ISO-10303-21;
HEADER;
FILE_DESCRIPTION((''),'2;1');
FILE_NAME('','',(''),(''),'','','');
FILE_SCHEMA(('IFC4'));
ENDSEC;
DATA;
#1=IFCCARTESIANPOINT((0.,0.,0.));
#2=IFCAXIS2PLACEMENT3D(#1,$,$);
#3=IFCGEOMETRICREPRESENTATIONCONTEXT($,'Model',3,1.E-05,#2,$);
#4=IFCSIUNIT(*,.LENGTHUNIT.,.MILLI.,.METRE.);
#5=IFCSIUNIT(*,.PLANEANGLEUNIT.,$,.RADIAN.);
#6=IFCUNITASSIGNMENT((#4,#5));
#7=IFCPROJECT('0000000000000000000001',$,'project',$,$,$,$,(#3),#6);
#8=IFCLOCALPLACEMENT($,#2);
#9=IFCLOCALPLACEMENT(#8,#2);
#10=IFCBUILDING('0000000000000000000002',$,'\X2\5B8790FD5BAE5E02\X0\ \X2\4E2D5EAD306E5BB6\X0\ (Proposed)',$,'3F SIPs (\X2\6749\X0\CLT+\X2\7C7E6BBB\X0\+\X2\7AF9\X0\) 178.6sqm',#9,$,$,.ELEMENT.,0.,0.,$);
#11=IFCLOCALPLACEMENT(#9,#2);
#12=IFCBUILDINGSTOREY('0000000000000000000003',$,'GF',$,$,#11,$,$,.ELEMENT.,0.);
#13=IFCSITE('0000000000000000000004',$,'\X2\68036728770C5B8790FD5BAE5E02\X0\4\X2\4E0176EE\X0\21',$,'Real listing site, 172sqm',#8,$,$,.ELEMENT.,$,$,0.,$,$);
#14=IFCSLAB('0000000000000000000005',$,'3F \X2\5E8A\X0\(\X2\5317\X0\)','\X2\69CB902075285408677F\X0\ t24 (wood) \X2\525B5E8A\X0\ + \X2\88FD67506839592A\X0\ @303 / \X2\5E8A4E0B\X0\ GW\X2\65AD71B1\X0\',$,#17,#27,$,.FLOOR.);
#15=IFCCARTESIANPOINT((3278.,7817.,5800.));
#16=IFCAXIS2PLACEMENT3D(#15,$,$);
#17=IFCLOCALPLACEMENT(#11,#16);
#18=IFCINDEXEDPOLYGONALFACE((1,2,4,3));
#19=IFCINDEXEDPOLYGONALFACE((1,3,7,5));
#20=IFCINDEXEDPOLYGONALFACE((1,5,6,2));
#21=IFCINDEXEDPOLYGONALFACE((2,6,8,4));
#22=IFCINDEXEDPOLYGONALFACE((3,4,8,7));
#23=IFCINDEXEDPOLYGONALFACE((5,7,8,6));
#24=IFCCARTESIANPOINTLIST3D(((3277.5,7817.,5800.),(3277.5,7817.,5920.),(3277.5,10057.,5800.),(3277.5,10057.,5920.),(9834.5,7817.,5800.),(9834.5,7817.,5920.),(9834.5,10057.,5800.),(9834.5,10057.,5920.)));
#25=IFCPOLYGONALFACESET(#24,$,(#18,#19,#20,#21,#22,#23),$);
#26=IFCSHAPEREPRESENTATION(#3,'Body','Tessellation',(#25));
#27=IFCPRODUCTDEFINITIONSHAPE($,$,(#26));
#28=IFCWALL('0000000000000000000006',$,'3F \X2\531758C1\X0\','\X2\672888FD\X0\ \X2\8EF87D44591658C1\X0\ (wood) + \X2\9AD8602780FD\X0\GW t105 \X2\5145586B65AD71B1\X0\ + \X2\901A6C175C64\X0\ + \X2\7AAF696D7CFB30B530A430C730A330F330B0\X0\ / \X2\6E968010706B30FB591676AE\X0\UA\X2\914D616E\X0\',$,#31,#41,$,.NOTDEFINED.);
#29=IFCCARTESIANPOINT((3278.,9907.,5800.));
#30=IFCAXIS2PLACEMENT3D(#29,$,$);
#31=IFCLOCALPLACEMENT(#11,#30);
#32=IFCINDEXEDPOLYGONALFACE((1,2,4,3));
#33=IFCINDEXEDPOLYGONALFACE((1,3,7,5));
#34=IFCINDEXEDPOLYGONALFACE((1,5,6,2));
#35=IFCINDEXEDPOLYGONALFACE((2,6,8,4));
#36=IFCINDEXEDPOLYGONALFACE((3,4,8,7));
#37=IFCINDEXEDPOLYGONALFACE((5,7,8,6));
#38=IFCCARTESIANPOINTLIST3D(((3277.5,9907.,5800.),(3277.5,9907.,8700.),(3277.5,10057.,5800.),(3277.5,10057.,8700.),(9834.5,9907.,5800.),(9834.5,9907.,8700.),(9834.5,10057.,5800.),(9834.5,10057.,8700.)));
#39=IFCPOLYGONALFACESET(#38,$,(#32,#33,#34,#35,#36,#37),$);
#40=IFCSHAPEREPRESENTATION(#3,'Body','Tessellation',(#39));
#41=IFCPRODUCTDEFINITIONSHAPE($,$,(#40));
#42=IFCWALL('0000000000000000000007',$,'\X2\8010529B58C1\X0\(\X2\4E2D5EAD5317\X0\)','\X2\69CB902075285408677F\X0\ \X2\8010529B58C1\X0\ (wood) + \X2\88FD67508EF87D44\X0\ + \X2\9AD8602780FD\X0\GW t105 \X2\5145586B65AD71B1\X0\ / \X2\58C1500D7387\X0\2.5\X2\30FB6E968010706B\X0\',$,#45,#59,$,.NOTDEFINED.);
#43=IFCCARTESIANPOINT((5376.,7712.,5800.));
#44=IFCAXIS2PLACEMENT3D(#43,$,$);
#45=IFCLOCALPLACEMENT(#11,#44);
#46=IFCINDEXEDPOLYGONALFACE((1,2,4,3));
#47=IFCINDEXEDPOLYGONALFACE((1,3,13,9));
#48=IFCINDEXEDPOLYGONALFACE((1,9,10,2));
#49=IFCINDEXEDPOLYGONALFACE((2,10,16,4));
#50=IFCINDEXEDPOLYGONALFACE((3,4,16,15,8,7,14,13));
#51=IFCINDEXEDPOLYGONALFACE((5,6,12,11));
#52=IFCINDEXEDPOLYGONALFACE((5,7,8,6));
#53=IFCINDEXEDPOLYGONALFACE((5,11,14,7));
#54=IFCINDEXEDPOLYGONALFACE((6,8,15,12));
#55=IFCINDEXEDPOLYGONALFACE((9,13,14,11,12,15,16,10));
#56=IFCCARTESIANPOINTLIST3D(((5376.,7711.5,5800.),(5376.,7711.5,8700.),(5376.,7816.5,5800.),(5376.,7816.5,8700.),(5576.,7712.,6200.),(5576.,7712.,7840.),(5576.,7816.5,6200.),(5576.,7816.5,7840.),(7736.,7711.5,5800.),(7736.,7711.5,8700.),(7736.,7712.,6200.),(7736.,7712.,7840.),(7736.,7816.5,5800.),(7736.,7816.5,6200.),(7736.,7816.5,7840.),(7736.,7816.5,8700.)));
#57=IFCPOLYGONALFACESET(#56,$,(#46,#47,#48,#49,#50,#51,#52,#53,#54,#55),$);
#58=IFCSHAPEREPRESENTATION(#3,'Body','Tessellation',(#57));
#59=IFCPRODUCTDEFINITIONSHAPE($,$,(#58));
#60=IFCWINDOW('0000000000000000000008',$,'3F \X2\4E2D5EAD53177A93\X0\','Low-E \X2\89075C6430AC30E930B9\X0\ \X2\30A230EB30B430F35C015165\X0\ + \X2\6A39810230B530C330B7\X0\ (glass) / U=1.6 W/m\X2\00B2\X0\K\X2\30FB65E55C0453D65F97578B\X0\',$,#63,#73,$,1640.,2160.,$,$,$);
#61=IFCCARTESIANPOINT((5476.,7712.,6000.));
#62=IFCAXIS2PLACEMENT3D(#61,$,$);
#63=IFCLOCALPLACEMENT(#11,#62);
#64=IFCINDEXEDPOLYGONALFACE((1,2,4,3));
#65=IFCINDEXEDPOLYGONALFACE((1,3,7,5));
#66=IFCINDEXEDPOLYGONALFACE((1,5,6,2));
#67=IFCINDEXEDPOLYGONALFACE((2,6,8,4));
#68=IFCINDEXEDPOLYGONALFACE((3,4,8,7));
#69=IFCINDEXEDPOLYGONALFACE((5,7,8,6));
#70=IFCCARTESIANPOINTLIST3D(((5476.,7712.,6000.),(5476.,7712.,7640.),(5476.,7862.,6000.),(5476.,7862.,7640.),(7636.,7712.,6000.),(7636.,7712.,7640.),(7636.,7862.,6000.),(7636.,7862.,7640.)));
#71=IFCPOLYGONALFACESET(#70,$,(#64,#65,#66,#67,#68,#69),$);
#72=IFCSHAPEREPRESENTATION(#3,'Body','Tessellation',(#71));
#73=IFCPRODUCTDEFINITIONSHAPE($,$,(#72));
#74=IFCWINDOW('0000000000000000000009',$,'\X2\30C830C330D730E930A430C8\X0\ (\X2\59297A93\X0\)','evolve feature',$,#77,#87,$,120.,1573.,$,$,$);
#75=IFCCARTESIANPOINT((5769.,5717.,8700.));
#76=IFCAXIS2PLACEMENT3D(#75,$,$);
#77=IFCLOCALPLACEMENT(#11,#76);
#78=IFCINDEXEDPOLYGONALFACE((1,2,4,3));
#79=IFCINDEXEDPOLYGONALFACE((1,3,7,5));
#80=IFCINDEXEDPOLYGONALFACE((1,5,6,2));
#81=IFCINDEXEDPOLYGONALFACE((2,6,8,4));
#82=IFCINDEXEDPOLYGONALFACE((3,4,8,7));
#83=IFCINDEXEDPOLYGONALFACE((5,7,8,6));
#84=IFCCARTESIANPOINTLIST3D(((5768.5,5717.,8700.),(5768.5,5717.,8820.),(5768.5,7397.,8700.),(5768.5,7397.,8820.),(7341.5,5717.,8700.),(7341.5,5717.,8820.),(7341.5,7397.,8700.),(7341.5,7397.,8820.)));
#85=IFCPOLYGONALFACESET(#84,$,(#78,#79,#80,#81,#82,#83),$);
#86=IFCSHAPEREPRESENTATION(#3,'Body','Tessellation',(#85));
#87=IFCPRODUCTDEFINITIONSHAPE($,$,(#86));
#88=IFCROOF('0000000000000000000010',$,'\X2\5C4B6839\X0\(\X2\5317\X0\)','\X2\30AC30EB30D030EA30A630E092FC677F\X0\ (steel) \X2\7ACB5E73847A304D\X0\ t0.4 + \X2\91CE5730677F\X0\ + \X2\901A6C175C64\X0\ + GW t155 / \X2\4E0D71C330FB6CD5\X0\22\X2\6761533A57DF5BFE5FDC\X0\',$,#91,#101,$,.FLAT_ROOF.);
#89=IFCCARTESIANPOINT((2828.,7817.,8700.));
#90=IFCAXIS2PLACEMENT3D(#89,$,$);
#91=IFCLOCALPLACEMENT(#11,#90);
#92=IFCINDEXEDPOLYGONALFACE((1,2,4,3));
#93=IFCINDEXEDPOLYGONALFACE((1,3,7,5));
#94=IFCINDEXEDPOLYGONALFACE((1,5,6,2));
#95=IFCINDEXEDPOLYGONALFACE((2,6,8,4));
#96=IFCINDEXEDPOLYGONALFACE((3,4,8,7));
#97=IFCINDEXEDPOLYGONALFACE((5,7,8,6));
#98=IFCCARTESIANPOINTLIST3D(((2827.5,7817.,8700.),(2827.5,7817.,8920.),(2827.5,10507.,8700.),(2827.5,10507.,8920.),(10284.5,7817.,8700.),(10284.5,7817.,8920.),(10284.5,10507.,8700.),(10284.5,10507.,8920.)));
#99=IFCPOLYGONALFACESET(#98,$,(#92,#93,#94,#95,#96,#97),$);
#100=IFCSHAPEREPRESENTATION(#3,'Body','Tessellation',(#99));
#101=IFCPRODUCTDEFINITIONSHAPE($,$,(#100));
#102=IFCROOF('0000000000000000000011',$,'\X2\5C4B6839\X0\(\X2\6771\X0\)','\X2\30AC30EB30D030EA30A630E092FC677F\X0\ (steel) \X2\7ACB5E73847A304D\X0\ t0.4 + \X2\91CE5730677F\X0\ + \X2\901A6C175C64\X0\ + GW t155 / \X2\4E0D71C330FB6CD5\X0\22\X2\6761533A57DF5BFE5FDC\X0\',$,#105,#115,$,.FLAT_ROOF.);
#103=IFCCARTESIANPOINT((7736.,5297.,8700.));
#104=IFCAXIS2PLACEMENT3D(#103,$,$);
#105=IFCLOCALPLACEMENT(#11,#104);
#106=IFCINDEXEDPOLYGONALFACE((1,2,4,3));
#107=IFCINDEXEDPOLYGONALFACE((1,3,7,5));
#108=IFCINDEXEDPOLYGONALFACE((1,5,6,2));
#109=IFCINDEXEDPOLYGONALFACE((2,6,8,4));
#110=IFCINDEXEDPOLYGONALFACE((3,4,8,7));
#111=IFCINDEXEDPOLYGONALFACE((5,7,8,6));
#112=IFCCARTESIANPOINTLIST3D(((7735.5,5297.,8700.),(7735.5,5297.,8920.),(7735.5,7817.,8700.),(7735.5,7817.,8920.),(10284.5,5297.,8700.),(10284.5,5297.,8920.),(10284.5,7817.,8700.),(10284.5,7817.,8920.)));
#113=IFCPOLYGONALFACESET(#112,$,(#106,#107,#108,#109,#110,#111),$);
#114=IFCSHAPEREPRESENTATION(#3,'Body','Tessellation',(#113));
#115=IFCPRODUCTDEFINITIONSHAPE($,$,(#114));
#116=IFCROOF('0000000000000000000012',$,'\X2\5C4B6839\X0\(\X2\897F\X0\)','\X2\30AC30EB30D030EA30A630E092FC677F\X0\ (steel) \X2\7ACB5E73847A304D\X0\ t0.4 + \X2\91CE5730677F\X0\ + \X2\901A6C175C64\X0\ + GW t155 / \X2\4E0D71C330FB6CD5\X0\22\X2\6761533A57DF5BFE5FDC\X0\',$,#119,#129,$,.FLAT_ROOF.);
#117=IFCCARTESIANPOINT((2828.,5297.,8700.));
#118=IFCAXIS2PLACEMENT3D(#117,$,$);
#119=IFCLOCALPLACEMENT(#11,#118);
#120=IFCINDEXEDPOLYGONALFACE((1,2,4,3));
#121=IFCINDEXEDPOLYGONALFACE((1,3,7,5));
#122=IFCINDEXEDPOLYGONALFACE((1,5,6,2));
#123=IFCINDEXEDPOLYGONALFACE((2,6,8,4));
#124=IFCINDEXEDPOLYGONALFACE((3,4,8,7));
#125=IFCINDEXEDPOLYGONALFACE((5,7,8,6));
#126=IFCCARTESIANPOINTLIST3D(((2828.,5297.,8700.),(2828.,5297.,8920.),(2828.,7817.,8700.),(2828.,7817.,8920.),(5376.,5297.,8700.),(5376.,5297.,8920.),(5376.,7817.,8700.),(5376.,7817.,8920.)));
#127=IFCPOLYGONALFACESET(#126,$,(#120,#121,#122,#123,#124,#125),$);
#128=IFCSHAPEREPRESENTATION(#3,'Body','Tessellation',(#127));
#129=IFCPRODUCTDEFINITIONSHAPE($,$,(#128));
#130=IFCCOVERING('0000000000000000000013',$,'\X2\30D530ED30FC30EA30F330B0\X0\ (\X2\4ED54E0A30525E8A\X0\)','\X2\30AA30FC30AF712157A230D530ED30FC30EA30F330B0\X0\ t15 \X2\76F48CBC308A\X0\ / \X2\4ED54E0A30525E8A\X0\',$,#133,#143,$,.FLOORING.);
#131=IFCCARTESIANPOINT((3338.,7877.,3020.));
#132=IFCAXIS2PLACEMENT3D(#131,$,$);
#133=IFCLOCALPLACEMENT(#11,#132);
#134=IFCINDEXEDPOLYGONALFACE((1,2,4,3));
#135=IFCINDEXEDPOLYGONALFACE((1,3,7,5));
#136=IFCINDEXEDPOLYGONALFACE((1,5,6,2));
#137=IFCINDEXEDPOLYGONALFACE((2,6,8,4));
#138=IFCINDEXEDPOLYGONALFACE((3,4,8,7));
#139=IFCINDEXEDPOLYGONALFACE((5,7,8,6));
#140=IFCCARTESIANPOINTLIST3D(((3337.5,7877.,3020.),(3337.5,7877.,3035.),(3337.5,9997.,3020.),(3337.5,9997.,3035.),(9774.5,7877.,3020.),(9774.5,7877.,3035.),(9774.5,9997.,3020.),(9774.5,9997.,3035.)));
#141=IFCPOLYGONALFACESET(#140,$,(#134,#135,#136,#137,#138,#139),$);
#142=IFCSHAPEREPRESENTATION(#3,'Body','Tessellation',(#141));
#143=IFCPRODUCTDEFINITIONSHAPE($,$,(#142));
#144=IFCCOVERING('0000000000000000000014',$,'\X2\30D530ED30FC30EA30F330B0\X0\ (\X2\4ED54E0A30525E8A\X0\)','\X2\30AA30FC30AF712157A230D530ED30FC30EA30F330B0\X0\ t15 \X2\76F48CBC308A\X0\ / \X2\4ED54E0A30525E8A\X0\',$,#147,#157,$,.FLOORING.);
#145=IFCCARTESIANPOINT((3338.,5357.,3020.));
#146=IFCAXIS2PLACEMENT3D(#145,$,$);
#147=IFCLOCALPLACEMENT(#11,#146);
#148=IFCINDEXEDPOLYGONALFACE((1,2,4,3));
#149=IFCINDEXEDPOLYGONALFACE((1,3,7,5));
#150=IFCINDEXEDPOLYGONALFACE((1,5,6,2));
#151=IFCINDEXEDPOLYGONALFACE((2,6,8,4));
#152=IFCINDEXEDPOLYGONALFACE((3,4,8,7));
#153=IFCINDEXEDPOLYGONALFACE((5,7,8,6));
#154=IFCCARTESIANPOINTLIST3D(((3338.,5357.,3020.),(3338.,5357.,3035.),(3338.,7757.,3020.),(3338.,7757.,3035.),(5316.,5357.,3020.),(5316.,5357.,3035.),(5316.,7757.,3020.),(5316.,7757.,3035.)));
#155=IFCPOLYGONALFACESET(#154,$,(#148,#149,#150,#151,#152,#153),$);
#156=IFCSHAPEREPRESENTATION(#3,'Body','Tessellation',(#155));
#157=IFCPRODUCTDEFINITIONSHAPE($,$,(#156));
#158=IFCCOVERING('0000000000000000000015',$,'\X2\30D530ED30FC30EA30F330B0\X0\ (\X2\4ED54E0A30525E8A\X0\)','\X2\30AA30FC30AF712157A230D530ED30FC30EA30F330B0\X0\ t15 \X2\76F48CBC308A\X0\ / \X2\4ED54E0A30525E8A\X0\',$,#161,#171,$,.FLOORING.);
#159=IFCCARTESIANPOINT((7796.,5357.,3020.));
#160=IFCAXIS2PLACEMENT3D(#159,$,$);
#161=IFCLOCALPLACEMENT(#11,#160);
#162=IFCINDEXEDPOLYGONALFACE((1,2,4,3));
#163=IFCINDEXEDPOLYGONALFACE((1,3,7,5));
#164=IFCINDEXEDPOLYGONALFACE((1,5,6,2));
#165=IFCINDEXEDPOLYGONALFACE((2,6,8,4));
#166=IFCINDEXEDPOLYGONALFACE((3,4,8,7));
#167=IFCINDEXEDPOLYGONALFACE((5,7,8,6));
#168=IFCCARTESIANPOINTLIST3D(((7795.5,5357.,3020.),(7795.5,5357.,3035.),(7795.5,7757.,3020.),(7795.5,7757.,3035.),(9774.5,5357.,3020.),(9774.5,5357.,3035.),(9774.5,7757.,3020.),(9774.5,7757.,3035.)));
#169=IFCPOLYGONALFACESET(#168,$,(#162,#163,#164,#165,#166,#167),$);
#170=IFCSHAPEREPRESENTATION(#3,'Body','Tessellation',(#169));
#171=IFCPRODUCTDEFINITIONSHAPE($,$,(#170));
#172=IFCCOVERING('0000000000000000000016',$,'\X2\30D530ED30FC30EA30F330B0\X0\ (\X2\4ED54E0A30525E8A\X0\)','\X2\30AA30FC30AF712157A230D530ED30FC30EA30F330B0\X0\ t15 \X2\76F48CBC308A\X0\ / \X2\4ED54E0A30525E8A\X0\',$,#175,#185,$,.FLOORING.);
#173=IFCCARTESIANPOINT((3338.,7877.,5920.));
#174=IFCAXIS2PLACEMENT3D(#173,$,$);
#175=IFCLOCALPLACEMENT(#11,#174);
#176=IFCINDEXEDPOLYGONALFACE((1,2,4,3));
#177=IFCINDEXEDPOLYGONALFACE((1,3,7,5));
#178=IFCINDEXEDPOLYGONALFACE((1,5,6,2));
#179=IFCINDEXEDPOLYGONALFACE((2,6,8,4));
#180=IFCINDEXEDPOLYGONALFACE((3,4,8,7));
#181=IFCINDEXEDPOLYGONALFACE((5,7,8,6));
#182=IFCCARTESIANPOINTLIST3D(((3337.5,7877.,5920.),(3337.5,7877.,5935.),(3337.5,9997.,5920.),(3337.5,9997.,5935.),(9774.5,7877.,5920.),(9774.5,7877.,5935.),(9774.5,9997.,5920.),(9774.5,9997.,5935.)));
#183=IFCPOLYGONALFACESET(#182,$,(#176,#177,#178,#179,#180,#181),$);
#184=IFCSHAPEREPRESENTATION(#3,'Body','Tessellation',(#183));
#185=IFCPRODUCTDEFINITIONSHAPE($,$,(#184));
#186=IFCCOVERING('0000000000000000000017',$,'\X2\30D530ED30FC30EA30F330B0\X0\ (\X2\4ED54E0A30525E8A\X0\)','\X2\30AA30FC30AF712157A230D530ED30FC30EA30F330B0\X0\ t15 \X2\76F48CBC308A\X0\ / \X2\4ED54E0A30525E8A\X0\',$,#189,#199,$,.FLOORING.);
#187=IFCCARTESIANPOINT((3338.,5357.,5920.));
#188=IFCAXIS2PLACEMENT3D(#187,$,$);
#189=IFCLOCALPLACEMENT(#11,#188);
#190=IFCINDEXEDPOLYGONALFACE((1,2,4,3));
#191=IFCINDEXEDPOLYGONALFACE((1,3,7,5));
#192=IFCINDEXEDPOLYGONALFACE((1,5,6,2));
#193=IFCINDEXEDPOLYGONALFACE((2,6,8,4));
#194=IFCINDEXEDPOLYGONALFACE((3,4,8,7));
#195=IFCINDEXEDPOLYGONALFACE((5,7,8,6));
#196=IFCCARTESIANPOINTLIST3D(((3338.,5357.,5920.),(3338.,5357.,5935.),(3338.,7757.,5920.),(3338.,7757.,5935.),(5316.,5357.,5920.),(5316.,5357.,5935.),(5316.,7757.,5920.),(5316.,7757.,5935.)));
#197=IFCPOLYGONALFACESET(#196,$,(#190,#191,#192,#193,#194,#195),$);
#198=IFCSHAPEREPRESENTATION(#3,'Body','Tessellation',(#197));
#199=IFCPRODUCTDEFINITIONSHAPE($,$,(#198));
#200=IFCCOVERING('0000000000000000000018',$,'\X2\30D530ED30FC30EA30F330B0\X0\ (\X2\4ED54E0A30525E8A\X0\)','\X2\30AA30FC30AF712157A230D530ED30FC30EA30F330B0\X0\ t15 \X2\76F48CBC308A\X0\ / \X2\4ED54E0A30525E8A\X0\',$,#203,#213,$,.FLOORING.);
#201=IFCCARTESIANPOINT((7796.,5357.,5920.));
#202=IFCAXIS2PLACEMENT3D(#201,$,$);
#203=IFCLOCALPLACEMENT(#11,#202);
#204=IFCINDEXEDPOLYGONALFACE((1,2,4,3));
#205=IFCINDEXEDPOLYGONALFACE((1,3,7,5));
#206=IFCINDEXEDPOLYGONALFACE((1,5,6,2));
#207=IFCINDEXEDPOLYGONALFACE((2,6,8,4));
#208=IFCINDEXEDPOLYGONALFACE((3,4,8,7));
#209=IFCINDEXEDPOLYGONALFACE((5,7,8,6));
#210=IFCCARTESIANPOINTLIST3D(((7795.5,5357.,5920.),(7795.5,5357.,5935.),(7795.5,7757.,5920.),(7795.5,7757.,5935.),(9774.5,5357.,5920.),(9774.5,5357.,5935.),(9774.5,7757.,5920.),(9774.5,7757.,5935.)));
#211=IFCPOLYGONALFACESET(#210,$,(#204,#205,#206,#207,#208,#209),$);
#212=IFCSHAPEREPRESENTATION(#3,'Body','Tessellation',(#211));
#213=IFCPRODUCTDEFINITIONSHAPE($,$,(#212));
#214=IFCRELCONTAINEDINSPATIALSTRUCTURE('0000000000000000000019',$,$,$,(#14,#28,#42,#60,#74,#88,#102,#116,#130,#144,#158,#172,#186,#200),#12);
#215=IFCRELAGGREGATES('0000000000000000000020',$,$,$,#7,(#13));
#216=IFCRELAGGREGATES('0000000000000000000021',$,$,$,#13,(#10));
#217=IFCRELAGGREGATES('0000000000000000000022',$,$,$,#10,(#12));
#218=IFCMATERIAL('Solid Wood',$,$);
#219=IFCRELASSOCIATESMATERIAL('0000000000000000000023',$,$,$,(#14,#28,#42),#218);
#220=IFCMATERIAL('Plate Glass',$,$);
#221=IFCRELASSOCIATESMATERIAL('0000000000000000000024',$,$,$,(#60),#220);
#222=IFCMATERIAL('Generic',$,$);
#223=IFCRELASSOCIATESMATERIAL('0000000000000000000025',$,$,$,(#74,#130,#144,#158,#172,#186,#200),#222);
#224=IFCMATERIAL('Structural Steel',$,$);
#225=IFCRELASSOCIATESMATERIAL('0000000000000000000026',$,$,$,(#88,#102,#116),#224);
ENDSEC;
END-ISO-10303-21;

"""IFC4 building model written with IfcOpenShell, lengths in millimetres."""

from ifc_helpers import new_model, si_unit, frame, frame_2d, origin, place, context, project, spatial, rectangle, extrude, material, element, fill, save


model = new_model("IFC4")

# Units and contexts
model_context = context("Model", 3, precision=1e-05, world=origin())
ifc_project = project(units=[si_unit("LENGTHUNIT", "METRE", prefix="MILLI"), si_unit("PLANEANGLEUNIT", "RADIAN")], contexts=[model_context])

# Site, building, storey
site_placement = place(None, origin())
site = spatial("IfcSite", under=ifc_project, at=site_placement, Name="栃木県宇都宮市4丁目21", ObjectType="Real listing site, 172sqm", CompositionType="ELEMENT", RefElevation=0.0)
building_placement = place(site_placement, origin())
building = spatial("IfcBuilding", under=site, at=building_placement, Name="宇都宮市 中庭の家 (Proposed)", ObjectType="3F SIPs (杉CLT+籾殻+竹) 178.6sqm", CompositionType="ELEMENT", ElevationOfRefHeight=0.0, ElevationOfTerrain=0.0)
storey_placement = place(building_placement, origin())
storey = spatial("IfcBuildingStorey", under=building, at=storey_placement, Name="GF", CompositionType="ELEMENT", Elevation=0.0)

# Slab
ifc_material_1 = material(Name="Solid Wood")
slab_placement = place(storey_placement, frame((3278.0, 7817.0, 5800.0)))
element("IfcSlab", 1, at=slab_placement, inside=storey, material=ifc_material_1, Name="3F 床(北)", Description="構造用合板 t24 (wood) 剛床 + 製材根太 @303 / 床下 GW断熱", PredefinedType="FLOOR", context=model_context, shape_type="SweptSolid", body=[
    extrude(rectangle(XDim=6557.0, YDim=2240.0, at=frame_2d((3278.0, 1120.0))), frame((3278.0, 7817.0, 5800.0)), (0.0, 0.0, 1.0), 120.0),
])

# Wall
wall_1_placement = place(storey_placement, frame((3278.0, 9907.0, 5800.0)))
element("IfcWall", 2, at=wall_1_placement, inside=storey, material=ifc_material_1, Name="3F 北壁", Description="木製 軸組外壁 (wood) + 高性能GW t105 充填断熱 + 通気層 + 窯業系サイディング / 準耐火・外皮UA配慮", PredefinedType="NOTDEFINED", context=model_context, shape_type="SweptSolid", body=[
    extrude(rectangle(XDim=6557.0, YDim=150.0, at=frame_2d((3278.0, 75.0))), frame((3278.0, 9907.0, 5800.0)), (0.0, 0.0, 1.0), 2900.0),
])

# Wall, opening, window
wall_2_placement = place(storey_placement, frame((5376.0, 7712.0, 5800.0)))
wall_2 = element("IfcWall", 3, at=wall_2_placement, inside=storey, material=ifc_material_1, Name="耐力壁(中庭北)", Description="構造用合板 耐力壁 (wood) + 製材軸組 + 高性能GW t105 充填断熱 / 壁倍率2.5・準耐火", PredefinedType="NOTDEFINED", context=model_context, shape_type="SweptSolid", body=[
    extrude(rectangle(XDim=2360.0, YDim=105.0, at=frame_2d((1180.0, 52.0))), frame((5376.0, 7712.0, 5800.0)), (0.0, 0.0, 1.0), 2900.0),
])
opening_placement = place(storey_placement, frame((5476.0, 7712.0, 6000.0)))
opening = element("IfcOpeningElement", 4, at=opening_placement, cuts=wall_2, PredefinedType="NOTDEFINED", context=model_context, shape_type="SweptSolid", body=[
    extrude(rectangle(XDim=2160.0, YDim=150.0, at=frame_2d((1080.0, 75.0))), frame((5476.0, 7712.0, 6000.0)), (0.0, 0.0, 1.0), 1640.0),
])
ifc_material_2 = material(Name="Plate Glass")
window_1_placement = place(storey_placement, frame((5476.0, 7712.0, 6000.0)))
window_1 = element("IfcWindow", 5, at=window_1_placement, inside=storey, material=ifc_material_2, Name="3F 中庭北窓", Description="Low-E 複層ガラス アルゴン封入 + 樹脂サッシ (glass) / U=1.6 W/m²K・日射取得型", OverallHeight=1640.0, OverallWidth=2160.0, context=model_context, shape_type="SweptSolid", body=[
    extrude(rectangle(XDim=2160.0, YDim=150.0, at=frame_2d((1080.0, 75.0))), frame((5476.0, 7712.0, 6000.0)), (0.0, 0.0, 1.0), 1640.0),
])
fill(opening, window_1)

# Window
ifc_material_3 = material(Name="Generic")
window_2_placement = place(storey_placement, frame((5769.0, 5717.0, 8700.0)))
element("IfcWindow", 6, at=window_2_placement, inside=storey, material=ifc_material_3, Name="トップライト (天窓)", Description="evolve feature", OverallHeight=120.0, OverallWidth=1573.0, context=model_context, shape_type="SweptSolid", body=[
    extrude(rectangle(XDim=1573.0, YDim=1680.0, at=frame_2d((786.0, 840.0))), frame((5769.0, 5717.0, 8700.0)), (0.0, 0.0, 1.0), 120.0),
])

# Roofs
ifc_material_4 = material(Name="Structural Steel")
roof_1_placement = place(storey_placement, frame((2828.0, 7817.0, 8700.0)))
element("IfcRoof", 7, at=roof_1_placement, inside=storey, material=ifc_material_4, Name="屋根(北)", Description="ガルバリウム鋼板 (steel) 立平葺き t0.4 + 野地板 + 通気層 + GW t155 / 不燃・法22条区域対応", PredefinedType="FLAT_ROOF", context=model_context, shape_type="SweptSolid", body=[
    extrude(rectangle(XDim=7457.0, YDim=2690.0, at=frame_2d((3728.0, 1345.0))), frame((2828.0, 7817.0, 8700.0)), (0.0, 0.0, 1.0), 220.0),
])
roof_2_placement = place(storey_placement, frame((7736.0, 5297.0, 8700.0)))
element("IfcRoof", 8, at=roof_2_placement, inside=storey, material=ifc_material_4, Name="屋根(東)", Description="ガルバリウム鋼板 (steel) 立平葺き t0.4 + 野地板 + 通気層 + GW t155 / 不燃・法22条区域対応", PredefinedType="FLAT_ROOF", context=model_context, shape_type="SweptSolid", body=[
    extrude(rectangle(XDim=2549.0, YDim=2520.0, at=frame_2d((1274.0, 1260.0))), frame((7736.0, 5297.0, 8700.0)), (0.0, 0.0, 1.0), 220.0),
])
roof_3_placement = place(storey_placement, frame((2828.0, 5297.0, 8700.0)))
element("IfcRoof", 9, at=roof_3_placement, inside=storey, material=ifc_material_4, Name="屋根(西)", Description="ガルバリウム鋼板 (steel) 立平葺き t0.4 + 野地板 + 通気層 + GW t155 / 不燃・法22条区域対応", PredefinedType="FLAT_ROOF", context=model_context, shape_type="SweptSolid", body=[
    extrude(rectangle(XDim=2548.0, YDim=2520.0, at=frame_2d((1274.0, 1260.0))), frame((2828.0, 5297.0, 8700.0)), (0.0, 0.0, 1.0), 220.0),
])

# Coverings
covering_1_placement = place(storey_placement, frame((3338.0, 7877.0, 3020.0)))
element("IfcCovering", 10, at=covering_1_placement, inside=storey, material=ifc_material_3, Name="フローリング (仕上げ床)", Description="オーク無垢フローリング t15 直貼り / 仕上げ床", PredefinedType="FLOORING", context=model_context, shape_type="SweptSolid", body=[
    extrude(rectangle(XDim=6437.0, YDim=2120.0, at=frame_2d((3218.0, 1060.0))), frame((3338.0, 7877.0, 3020.0)), (0.0, 0.0, 1.0), 15.0),
])
covering_2_placement = place(storey_placement, frame((3338.0, 5357.0, 3020.0)))
element("IfcCovering", 11, at=covering_2_placement, inside=storey, material=ifc_material_3, Name="フローリング (仕上げ床)", Description="オーク無垢フローリング t15 直貼り / 仕上げ床", PredefinedType="FLOORING", context=model_context, shape_type="SweptSolid", body=[
    extrude(rectangle(XDim=1978.0, YDim=2400.0, at=frame_2d((989.0, 1200.0))), frame((3338.0, 5357.0, 3020.0)), (0.0, 0.0, 1.0), 15.0),
])
covering_3_placement = place(storey_placement, frame((7796.0, 5357.0, 3020.0)))
element("IfcCovering", 12, at=covering_3_placement, inside=storey, material=ifc_material_3, Name="フローリング (仕上げ床)", Description="オーク無垢フローリング t15 直貼り / 仕上げ床", PredefinedType="FLOORING", context=model_context, shape_type="SweptSolid", body=[
    extrude(rectangle(XDim=1979.0, YDim=2400.0, at=frame_2d((989.0, 1200.0))), frame((7796.0, 5357.0, 3020.0)), (0.0, 0.0, 1.0), 15.0),
])
covering_4_placement = place(storey_placement, frame((3338.0, 7877.0, 5920.0)))
element("IfcCovering", 13, at=covering_4_placement, inside=storey, material=ifc_material_3, Name="フローリング (仕上げ床)", Description="オーク無垢フローリング t15 直貼り / 仕上げ床", PredefinedType="FLOORING", context=model_context, shape_type="SweptSolid", body=[
    extrude(rectangle(XDim=6437.0, YDim=2120.0, at=frame_2d((3218.0, 1060.0))), frame((3338.0, 7877.0, 5920.0)), (0.0, 0.0, 1.0), 15.0),
])
covering_5_placement = place(storey_placement, frame((3338.0, 5357.0, 5920.0)))
element("IfcCovering", 14, at=covering_5_placement, inside=storey, material=ifc_material_3, Name="フローリング (仕上げ床)", Description="オーク無垢フローリング t15 直貼り / 仕上げ床", PredefinedType="FLOORING", context=model_context, shape_type="SweptSolid", body=[
    extrude(rectangle(XDim=1978.0, YDim=2400.0, at=frame_2d((989.0, 1200.0))), frame((3338.0, 5357.0, 5920.0)), (0.0, 0.0, 1.0), 15.0),
])
covering_6_placement = place(storey_placement, frame((7796.0, 5357.0, 5920.0)))
element("IfcCovering", 15, at=covering_6_placement, inside=storey, material=ifc_material_3, Name="フローリング (仕上げ床)", Description="オーク無垢フローリング t15 直貼り / 仕上げ床", PredefinedType="FLOORING", context=model_context, shape_type="SweptSolid", body=[
    extrude(rectangle(XDim=1979.0, YDim=2400.0, at=frame_2d((989.0, 1200.0))), frame((7796.0, 5357.0, 5920.0)), (0.0, 0.0, 1.0), 15.0),
])

save(model, "model.ifc")
